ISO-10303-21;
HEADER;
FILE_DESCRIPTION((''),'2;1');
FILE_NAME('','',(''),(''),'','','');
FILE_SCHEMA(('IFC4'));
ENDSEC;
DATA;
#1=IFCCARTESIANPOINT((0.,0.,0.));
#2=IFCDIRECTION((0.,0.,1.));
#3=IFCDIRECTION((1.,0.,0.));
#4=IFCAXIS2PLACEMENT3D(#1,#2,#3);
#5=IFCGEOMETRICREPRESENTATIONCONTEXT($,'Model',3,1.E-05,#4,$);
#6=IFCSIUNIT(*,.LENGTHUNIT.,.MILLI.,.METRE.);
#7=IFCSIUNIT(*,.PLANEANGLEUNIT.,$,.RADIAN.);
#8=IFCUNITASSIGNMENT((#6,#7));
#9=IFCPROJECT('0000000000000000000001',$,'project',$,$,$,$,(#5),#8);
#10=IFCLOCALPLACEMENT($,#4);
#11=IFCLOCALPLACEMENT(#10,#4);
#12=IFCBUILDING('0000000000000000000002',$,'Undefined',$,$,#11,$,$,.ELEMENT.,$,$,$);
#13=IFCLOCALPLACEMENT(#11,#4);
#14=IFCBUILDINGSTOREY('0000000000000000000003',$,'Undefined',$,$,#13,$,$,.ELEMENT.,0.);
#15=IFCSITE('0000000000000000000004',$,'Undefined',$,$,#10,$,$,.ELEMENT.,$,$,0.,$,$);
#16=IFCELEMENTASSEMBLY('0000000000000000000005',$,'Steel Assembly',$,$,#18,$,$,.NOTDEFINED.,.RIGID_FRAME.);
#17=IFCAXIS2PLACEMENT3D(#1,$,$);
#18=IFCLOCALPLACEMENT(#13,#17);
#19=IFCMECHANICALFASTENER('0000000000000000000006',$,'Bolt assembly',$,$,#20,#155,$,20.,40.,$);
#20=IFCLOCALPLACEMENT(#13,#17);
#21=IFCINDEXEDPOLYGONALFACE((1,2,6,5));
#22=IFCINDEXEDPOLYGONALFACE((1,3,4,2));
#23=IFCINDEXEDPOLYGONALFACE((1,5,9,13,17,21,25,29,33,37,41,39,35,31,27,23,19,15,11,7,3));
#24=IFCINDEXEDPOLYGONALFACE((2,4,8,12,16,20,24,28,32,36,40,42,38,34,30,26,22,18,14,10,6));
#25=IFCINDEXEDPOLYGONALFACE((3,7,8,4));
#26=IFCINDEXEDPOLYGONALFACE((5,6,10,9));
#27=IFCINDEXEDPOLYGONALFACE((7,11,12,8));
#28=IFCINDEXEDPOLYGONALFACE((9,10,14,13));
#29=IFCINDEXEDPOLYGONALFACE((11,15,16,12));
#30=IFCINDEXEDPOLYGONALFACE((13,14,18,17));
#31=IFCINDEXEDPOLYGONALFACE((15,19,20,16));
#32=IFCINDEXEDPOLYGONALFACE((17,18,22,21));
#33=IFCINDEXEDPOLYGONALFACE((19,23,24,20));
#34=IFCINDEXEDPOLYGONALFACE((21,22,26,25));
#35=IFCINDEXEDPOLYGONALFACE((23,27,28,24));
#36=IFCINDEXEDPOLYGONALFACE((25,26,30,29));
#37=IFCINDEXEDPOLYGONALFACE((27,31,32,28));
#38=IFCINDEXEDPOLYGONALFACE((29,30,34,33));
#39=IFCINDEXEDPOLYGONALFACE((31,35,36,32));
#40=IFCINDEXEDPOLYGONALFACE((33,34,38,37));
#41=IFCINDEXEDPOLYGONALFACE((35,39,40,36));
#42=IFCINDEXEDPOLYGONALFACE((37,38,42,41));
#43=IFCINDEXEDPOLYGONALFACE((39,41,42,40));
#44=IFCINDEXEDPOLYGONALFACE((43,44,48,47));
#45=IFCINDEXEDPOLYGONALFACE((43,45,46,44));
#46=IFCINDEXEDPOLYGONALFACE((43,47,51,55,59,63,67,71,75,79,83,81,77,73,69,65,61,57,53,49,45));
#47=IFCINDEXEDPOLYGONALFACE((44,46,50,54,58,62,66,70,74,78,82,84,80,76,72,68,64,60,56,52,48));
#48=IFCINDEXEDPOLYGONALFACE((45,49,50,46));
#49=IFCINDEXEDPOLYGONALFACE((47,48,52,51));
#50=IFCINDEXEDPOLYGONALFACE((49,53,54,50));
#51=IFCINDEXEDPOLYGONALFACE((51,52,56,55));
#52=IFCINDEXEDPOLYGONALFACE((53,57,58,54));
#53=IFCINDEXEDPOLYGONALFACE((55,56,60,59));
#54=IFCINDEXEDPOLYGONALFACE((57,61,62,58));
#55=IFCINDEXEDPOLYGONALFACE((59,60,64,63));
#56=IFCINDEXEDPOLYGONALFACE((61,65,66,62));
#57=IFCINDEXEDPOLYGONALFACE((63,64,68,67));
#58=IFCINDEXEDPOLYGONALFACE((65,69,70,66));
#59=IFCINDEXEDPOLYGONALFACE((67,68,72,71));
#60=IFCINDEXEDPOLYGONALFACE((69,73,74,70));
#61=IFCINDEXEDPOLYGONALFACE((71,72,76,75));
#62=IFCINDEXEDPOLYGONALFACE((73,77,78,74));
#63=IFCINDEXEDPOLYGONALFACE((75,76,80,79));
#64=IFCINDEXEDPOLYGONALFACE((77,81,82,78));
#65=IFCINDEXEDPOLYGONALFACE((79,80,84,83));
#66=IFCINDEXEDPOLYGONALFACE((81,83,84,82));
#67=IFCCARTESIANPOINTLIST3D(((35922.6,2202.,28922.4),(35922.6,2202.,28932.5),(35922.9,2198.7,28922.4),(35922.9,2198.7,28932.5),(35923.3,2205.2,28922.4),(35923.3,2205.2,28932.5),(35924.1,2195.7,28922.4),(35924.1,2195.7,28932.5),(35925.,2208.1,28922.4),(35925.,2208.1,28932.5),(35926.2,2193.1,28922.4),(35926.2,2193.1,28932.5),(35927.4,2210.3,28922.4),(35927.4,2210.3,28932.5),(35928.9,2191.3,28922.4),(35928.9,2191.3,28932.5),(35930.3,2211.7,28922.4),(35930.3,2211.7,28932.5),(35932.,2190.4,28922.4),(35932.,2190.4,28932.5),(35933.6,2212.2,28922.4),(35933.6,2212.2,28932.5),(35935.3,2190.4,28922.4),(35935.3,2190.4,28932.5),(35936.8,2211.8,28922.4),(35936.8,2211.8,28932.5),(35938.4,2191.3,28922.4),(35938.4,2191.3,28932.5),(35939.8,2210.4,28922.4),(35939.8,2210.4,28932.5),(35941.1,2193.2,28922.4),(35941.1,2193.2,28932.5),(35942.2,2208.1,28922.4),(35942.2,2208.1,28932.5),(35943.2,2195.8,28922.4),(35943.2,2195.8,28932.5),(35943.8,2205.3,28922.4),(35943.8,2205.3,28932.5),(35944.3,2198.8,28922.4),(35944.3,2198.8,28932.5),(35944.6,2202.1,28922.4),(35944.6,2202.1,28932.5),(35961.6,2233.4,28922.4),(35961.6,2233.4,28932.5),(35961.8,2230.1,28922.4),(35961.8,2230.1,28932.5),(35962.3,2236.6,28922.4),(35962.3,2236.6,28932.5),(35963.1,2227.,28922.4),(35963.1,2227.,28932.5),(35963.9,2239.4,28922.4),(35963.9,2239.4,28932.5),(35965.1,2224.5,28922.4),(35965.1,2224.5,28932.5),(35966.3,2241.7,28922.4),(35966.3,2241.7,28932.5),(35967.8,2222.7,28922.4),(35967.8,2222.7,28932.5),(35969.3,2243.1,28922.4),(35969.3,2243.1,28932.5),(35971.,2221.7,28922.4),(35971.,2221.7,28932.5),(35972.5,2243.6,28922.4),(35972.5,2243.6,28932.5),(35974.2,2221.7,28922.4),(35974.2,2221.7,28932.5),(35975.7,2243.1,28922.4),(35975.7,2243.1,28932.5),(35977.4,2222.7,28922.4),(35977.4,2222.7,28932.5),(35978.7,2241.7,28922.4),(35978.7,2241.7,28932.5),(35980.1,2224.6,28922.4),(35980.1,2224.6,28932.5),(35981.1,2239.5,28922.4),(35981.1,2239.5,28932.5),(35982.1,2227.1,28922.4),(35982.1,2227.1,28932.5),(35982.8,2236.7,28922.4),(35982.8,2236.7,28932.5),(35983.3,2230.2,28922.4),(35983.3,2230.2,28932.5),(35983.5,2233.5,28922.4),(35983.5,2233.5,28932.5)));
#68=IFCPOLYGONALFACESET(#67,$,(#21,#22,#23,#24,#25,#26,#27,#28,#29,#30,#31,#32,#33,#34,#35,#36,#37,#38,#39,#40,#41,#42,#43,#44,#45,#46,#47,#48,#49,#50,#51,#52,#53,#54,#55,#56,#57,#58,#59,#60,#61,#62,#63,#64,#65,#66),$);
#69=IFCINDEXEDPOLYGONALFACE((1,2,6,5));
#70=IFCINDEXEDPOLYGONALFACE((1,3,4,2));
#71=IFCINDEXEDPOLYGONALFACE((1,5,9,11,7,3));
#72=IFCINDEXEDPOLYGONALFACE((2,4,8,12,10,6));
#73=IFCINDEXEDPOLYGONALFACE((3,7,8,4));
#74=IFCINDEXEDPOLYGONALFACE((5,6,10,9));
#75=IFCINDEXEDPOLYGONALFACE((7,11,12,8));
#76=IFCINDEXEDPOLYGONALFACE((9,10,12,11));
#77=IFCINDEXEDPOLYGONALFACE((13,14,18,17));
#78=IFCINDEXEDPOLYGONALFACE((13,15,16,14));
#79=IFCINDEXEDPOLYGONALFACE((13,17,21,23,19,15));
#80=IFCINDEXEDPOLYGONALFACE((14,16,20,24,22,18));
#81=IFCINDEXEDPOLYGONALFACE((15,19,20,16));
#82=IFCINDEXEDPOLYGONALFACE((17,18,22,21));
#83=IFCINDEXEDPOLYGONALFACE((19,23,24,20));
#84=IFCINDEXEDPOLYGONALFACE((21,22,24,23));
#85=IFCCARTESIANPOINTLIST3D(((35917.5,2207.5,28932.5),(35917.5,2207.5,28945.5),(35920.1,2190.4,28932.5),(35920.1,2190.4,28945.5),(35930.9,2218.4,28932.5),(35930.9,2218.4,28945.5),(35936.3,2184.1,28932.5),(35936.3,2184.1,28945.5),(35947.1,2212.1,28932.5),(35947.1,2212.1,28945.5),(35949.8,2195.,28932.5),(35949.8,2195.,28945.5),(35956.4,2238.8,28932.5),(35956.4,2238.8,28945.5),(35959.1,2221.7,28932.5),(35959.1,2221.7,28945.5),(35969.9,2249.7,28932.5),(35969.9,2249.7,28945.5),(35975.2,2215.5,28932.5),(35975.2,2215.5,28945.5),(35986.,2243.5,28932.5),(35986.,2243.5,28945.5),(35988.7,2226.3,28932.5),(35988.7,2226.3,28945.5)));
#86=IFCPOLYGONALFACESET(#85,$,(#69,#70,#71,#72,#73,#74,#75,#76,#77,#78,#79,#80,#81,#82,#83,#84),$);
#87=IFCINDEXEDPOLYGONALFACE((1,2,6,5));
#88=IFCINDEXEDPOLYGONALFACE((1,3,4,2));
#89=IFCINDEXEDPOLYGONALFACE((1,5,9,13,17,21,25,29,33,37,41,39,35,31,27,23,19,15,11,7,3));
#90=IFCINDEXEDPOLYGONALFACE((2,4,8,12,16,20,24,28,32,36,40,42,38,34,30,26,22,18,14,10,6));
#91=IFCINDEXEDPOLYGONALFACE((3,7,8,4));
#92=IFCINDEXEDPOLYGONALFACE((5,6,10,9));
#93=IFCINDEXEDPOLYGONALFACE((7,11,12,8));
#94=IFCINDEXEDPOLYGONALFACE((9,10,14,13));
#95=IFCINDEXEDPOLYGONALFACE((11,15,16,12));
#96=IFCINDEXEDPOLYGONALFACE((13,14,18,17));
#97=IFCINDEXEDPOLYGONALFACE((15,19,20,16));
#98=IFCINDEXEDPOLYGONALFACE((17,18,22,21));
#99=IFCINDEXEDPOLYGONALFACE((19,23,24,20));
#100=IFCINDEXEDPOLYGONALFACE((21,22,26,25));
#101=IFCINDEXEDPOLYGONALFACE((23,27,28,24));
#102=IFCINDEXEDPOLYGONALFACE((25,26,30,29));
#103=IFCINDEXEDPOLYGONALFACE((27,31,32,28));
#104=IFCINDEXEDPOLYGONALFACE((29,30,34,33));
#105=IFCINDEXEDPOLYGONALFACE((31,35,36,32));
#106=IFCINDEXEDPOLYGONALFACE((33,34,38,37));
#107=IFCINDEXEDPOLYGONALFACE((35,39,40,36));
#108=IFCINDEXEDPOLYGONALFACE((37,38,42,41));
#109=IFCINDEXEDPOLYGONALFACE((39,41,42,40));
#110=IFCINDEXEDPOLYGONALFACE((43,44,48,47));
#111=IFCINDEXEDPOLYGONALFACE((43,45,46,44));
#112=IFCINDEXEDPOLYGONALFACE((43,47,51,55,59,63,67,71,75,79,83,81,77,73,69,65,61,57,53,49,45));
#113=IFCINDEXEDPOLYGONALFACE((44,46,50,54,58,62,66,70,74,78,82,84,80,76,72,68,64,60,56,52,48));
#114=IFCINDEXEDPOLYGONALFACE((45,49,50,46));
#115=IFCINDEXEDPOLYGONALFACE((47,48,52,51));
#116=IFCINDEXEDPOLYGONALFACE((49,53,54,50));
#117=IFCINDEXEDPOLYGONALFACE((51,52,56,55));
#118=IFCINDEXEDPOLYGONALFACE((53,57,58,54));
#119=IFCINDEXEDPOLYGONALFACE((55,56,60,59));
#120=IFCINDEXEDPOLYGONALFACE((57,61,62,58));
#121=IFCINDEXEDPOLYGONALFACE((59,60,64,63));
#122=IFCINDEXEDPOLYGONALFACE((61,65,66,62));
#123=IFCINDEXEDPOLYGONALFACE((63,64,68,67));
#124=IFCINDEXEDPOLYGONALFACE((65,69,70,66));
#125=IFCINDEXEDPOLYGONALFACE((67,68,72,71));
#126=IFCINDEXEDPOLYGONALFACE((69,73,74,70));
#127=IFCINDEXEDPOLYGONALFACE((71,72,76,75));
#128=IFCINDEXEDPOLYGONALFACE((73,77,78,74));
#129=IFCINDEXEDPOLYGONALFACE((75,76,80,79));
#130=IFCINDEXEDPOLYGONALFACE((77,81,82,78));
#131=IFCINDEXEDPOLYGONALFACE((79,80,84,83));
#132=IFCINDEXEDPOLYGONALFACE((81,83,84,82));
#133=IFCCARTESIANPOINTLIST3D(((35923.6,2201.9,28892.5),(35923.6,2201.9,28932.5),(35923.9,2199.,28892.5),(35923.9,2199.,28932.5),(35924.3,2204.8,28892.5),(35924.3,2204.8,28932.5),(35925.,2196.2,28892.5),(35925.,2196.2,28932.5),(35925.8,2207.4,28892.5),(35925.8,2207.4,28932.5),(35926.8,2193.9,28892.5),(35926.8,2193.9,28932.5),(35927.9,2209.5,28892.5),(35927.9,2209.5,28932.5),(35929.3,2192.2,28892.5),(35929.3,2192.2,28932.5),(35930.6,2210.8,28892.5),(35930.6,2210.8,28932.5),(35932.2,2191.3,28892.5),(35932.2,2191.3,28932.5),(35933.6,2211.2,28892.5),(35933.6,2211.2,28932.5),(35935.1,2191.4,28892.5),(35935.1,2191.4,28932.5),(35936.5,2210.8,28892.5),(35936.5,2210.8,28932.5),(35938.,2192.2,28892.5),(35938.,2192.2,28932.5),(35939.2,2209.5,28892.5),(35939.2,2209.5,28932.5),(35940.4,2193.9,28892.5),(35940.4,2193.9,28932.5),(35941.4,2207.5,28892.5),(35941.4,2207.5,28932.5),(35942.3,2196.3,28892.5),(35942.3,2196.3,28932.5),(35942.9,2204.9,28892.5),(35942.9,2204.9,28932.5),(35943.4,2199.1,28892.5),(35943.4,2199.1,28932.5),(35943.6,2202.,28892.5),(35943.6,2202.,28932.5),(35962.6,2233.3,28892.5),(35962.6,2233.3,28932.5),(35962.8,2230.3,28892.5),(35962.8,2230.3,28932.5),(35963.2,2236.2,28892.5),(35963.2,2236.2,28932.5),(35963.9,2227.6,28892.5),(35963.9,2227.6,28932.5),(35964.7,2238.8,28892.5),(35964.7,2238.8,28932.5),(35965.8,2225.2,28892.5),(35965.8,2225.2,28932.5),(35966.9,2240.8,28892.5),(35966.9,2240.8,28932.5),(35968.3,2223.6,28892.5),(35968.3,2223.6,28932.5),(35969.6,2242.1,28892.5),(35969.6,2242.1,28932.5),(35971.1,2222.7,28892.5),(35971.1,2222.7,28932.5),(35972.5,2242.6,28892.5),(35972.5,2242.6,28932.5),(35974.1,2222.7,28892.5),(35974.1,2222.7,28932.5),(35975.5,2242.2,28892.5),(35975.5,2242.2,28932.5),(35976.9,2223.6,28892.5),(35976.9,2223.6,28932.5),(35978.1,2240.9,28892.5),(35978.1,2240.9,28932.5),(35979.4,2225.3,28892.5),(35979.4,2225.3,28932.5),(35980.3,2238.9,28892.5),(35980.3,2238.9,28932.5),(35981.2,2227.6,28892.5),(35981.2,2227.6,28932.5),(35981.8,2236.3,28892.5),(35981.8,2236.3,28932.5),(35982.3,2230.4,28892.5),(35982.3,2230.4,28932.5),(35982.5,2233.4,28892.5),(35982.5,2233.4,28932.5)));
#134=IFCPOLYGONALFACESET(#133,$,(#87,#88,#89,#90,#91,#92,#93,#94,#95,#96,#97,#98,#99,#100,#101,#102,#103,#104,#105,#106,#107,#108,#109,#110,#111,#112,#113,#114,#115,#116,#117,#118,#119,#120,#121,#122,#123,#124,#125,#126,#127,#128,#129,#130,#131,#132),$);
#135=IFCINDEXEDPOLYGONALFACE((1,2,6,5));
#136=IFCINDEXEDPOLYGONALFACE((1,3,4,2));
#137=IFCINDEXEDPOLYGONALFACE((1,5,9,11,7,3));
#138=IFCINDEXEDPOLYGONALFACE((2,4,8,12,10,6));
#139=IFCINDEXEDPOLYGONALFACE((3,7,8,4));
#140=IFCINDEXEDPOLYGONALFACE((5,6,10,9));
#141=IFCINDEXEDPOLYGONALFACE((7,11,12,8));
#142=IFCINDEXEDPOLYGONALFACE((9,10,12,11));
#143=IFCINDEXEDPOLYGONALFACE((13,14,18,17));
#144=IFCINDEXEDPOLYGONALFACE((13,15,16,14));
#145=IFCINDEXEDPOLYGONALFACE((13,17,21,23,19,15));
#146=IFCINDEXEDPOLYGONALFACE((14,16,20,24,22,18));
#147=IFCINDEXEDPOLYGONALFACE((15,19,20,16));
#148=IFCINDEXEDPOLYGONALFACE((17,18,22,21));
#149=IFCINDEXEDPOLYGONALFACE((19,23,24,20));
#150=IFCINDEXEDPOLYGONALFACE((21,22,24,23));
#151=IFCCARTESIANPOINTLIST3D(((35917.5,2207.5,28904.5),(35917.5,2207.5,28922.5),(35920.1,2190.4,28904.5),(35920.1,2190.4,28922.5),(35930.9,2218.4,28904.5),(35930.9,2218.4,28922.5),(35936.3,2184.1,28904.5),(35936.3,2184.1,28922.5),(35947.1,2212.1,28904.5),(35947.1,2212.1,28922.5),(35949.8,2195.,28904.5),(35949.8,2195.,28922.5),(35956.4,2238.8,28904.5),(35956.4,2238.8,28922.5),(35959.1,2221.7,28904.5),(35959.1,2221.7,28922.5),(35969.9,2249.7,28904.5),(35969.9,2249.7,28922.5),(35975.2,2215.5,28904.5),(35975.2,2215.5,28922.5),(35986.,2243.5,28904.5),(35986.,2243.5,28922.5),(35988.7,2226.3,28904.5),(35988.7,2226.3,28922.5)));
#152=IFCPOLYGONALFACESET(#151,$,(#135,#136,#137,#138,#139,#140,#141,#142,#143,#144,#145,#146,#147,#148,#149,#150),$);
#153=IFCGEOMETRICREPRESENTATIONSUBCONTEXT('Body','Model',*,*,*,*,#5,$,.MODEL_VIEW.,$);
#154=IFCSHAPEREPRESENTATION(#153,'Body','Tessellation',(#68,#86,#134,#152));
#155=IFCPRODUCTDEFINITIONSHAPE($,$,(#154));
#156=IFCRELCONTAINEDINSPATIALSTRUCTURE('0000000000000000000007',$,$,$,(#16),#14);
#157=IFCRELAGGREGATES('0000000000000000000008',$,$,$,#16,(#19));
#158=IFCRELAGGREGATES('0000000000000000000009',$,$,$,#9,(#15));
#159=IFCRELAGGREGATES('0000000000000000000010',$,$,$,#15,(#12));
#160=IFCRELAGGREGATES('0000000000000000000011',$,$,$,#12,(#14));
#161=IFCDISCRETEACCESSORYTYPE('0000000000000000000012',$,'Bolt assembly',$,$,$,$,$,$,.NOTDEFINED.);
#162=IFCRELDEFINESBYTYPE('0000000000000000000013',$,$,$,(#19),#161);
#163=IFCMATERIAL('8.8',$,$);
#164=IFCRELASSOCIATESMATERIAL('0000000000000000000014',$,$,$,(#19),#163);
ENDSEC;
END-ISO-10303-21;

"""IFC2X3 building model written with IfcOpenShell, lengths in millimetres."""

from ifc_helpers import new_model, si_unit, frame, origin_with_axes, origin_2d_with_axis, place, context, subcontext, project, spatial, polyline, circle, outline, extrude, source, transform, mapped, material, type_object, element, aggregate, save


model = new_model("IFC2X3")

# Units and contexts
model_context = context("Model", 3, precision=1e-05, world=origin_with_axes())
body_context = subcontext(model_context, "Body", "Model", "MODEL_VIEW")
ifc_project = project(units=[si_unit("LENGTHUNIT", "METRE", prefix="MILLI"), si_unit("PLANEANGLEUNIT", "RADIAN")], contexts=[model_context])

# Site, building, storey
site_placement = place(None, origin_with_axes())
site = spatial("IfcSite", under=ifc_project, at=site_placement, Name="Undefined", CompositionType="ELEMENT", RefElevation=0.0)
building_placement = place(site_placement, origin_with_axes())
building = spatial("IfcBuilding", under=site, at=building_placement, Name="Undefined", CompositionType="ELEMENT")
storey_placement = place(building_placement, origin_with_axes())
storey = spatial("IfcBuildingStorey", under=building, at=storey_placement, Name="Undefined", CompositionType="ELEMENT", Elevation=0.0)

# Element assembly
assembly_1_placement = place(storey_placement, origin_with_axes())
assembly_1 = element("IfcElementAssembly", 1, at=assembly_1_placement, inside=storey, Name="Steel Assembly", AssemblyPlace="NOTDEFINED", PredefinedType="RIGID_FRAME")

# Shared definitions
discrete_accessory_type_1 = type_object("IfcDiscreteAccessoryType", Name="Bolt assembly")

# Shared definitions
ifc_material_1 = material(Name="8.8")

# Mechanical fastener
shared_shape_1 = source(origin_with_axes(), body_context, "Body", "SweptSolid", [
    extrude(circle(Radius=11.0, at=origin_2d_with_axis()), frame((0.0, -10.0, 0.0), z_axis=(0.0, 1.0, 0.0), x_axis=(1.0, 0.0, 0.0)), (0.0, 0.0, 1.0), 10.1),
    extrude(outline(polyline([(17.3, 0.0), (8.7, 15.0), (-8.7, 15.0), (-17.3, 0.0), (-8.7, -15.0), (8.7, -15.0), (17.3, 0.0)])), frame((0.0, -23.0, 0.0), z_axis=(0.0, 1.0, 0.0), x_axis=(1.0, 0.0, 0.0)), (0.0, 0.0, 1.0), 13.0),
    extrude(circle(Radius=10.0, at=origin_2d_with_axis()), frame((0.0, -10.0, 0.0), z_axis=(0.0, 1.0, 0.0), x_axis=(1.0, 0.0, 0.0)), (0.0, 0.0, 1.0), 40.0),
    extrude(outline(polyline([(17.3, 0.0), (8.7, 15.0), (-8.7, 15.0), (-17.3, 0.0), (-8.7, -15.0), (8.7, -15.0), (17.3, 0.0)])), frame((0.0, 0.0, 0.0), z_axis=(0.0, 1.0, 0.0), x_axis=(1.0, 0.0, 0.0)), (0.0, 0.0, 1.0), 18.0),
])
mechanical_fastener_1_placement = place(assembly_1_placement, frame((35933.6, 2201.2, 28922.5), z_axis=(-0.627081, 0.778954, 0.0), x_axis=(0.778954, 0.627081, 0.0)))
mechanical_fastener_1 = element("IfcMechanicalFastener", 2, at=mechanical_fastener_1_placement, type_object=discrete_accessory_type_1, material=ifc_material_1, Name="Bolt assembly", NominalDiameter=20.0, NominalLength=40.0, context=body_context, shape_type="MappedRepresentation", body=[
    mapped(shared_shape_1, transform((0.0, 0.0, 0.0))),
    mapped(shared_shape_1, transform((50.0, 0.0, 0.0))),
])
aggregate(assembly_1, [mechanical_fastener_1])

save(model, "model.ifc")
